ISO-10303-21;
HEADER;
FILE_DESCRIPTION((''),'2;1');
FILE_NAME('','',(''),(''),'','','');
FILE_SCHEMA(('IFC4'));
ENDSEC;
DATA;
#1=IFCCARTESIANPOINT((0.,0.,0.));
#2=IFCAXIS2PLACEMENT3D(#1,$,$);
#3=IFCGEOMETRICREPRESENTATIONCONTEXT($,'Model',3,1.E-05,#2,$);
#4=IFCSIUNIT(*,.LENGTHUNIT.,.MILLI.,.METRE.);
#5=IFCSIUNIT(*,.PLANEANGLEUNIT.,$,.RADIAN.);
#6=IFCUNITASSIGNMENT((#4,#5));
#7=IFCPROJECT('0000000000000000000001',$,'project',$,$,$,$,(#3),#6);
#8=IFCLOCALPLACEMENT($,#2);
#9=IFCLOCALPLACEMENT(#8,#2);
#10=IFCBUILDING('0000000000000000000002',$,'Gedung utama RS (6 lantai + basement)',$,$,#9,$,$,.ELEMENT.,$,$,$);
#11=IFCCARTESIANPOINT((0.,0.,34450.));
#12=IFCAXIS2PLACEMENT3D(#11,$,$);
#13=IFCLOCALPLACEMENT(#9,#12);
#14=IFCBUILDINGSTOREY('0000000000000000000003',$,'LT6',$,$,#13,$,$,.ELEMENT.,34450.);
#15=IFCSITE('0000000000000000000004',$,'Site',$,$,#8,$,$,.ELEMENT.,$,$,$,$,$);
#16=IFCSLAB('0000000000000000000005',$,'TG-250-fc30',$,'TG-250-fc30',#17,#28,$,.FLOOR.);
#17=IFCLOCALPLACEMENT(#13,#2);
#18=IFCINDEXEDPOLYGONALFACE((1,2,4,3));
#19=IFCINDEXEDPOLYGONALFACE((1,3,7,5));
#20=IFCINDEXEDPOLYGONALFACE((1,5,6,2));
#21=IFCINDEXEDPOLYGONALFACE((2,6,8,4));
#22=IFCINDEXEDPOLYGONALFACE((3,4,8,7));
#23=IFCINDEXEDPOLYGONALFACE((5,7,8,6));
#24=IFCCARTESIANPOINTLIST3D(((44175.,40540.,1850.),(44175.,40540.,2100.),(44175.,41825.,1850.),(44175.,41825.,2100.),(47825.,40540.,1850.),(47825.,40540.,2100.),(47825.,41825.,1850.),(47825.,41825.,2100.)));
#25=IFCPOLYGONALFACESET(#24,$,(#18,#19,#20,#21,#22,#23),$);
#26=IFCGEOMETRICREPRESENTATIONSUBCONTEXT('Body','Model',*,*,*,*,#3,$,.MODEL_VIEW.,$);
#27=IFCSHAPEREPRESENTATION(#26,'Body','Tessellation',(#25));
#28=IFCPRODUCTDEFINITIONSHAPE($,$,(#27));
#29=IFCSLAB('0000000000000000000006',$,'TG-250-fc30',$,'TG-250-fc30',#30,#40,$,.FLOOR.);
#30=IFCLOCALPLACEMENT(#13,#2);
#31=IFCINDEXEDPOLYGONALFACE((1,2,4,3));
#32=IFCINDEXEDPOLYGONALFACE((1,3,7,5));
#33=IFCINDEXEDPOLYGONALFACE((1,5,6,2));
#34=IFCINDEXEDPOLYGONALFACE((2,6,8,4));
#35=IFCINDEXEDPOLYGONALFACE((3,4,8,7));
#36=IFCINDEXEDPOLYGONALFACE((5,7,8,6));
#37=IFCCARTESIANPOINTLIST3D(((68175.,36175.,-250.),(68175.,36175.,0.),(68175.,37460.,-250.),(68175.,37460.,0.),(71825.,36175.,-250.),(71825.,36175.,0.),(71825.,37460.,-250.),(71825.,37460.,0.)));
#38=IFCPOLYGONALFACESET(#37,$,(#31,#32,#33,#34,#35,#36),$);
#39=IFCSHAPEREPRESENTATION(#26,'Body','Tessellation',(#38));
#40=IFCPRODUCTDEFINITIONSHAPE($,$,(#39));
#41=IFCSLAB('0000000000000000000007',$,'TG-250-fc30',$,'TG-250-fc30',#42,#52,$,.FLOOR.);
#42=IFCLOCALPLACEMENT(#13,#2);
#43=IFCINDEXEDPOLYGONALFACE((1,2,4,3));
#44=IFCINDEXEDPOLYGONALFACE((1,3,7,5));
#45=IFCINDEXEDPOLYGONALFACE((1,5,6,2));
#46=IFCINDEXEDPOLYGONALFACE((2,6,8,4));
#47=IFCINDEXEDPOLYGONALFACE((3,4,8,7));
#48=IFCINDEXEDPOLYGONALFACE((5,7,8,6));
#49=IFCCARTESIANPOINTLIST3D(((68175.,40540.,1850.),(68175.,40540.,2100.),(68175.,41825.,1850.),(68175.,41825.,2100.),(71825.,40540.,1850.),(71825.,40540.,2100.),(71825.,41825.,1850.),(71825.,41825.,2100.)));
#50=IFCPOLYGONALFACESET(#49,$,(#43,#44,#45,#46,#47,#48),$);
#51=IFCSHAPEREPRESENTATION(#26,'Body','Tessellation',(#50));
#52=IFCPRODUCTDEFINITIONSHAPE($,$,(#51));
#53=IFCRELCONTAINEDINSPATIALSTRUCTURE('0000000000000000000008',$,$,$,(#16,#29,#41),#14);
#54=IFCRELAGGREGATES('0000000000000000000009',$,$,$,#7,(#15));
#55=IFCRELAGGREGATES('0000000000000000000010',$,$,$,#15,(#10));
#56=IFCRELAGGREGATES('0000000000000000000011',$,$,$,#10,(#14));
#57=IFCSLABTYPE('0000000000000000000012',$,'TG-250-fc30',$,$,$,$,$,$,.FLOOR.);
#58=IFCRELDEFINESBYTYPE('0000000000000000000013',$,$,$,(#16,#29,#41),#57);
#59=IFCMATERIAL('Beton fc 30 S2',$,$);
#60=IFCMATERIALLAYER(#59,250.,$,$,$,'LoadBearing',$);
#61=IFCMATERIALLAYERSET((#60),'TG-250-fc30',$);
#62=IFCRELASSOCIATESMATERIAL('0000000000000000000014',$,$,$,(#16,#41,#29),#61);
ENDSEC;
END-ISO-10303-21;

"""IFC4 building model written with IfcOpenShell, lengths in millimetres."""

from ifc_helpers import new_model, si_unit, frame, origin, place, context, subcontext, project, spatial, polyline, outline, extrude, material, layer, layer_set, layer_usage, type_object, element, save


model = new_model("IFC4")

# Units and contexts
model_context = context("Model", 3, precision=1e-05, world=origin())
body_context = subcontext(model_context, "Body", "Model", "MODEL_VIEW")
ifc_project = project(units=[si_unit("LENGTHUNIT", "METRE", prefix="MILLI"), si_unit("PLANEANGLEUNIT", "RADIAN")], contexts=[model_context])

# Site, building, storey
site_placement = place(None, origin())
site = spatial("IfcSite", under=ifc_project, at=site_placement, Name="Site", CompositionType="ELEMENT")
building_placement = place(site_placement, origin())
building = spatial("IfcBuilding", under=site, at=building_placement, Name="Gedung utama RS (6 lantai + basement)", CompositionType="ELEMENT")
storey_placement = place(building_placement, frame((0.0, 0.0, 34450.0)))
storey = spatial("IfcBuildingStorey", under=building, at=storey_placement, Name="LT6", CompositionType="ELEMENT", Elevation=34450.0)

# Shared definitions
ifc_material = material(Name="Beton fc 30 S2")

# Slabs
ifc_layer_1 = layer(ifc_material, 250.0, Category="LoadBearing")
ifc_layer_set_1 = layer_set([ifc_layer_1], Name="TG-250-fc30")
ifc_layer_usage_1 = layer_usage(ifc_layer_set_1, "AXIS3", "NEGATIVE", 0.0)
slab_type_1 = type_object("IfcSlabType", Name="TG-250-fc30", PredefinedType="FLOOR")
ifc_layer_usage_2 = layer_usage(ifc_layer_set_1, "AXIS3", "NEGATIVE", 2100.0)
slab_1_placement = place(storey_placement, origin())
element("IfcSlab", 1, at=slab_1_placement, inside=storey, type_object=slab_type_1, material=ifc_layer_usage_2, Name="TG-250-fc30", ObjectType="TG-250-fc30", PredefinedType="FLOOR", context=body_context, shape_type="SweptSolid", body=[
    extrude(outline(polyline([(47825.0, 40540.0), (47825.0, 41825.0), (44175.0, 41825.0), (44175.0, 40540.0), (47825.0, 40540.0)])), frame((0.0, 0.0, 1850.0)), (0.0, 0.0, 1.0), 250.0),
])
slab_2_placement = place(storey_placement, origin())
element("IfcSlab", 2, at=slab_2_placement, inside=storey, type_object=slab_type_1, material=ifc_layer_usage_1, Name="TG-250-fc30", ObjectType="TG-250-fc30", PredefinedType="FLOOR", context=body_context, shape_type="SweptSolid", body=[
    extrude(outline(polyline([(71825.0, 36175.0), (71825.0, 37460.0), (68175.0, 37460.0), (68175.0, 36175.0), (71825.0, 36175.0)])), frame((0.0, 0.0, -250.0)), (0.0, 0.0, 1.0), 250.0),
])
slab_3_placement = place(storey_placement, origin())
element("IfcSlab", 3, at=slab_3_placement, inside=storey, type_object=slab_type_1, material=ifc_layer_usage_2, Name="TG-250-fc30", ObjectType="TG-250-fc30", PredefinedType="FLOOR", context=body_context, shape_type="SweptSolid", body=[
    extrude(outline(polyline([(71825.0, 40540.0), (71825.0, 41825.0), (68175.0, 41825.0), (68175.0, 40540.0), (71825.0, 40540.0)])), frame((0.0, 0.0, 1850.0)), (0.0, 0.0, 1.0), 250.0),
])

save(model, "model.ifc")
